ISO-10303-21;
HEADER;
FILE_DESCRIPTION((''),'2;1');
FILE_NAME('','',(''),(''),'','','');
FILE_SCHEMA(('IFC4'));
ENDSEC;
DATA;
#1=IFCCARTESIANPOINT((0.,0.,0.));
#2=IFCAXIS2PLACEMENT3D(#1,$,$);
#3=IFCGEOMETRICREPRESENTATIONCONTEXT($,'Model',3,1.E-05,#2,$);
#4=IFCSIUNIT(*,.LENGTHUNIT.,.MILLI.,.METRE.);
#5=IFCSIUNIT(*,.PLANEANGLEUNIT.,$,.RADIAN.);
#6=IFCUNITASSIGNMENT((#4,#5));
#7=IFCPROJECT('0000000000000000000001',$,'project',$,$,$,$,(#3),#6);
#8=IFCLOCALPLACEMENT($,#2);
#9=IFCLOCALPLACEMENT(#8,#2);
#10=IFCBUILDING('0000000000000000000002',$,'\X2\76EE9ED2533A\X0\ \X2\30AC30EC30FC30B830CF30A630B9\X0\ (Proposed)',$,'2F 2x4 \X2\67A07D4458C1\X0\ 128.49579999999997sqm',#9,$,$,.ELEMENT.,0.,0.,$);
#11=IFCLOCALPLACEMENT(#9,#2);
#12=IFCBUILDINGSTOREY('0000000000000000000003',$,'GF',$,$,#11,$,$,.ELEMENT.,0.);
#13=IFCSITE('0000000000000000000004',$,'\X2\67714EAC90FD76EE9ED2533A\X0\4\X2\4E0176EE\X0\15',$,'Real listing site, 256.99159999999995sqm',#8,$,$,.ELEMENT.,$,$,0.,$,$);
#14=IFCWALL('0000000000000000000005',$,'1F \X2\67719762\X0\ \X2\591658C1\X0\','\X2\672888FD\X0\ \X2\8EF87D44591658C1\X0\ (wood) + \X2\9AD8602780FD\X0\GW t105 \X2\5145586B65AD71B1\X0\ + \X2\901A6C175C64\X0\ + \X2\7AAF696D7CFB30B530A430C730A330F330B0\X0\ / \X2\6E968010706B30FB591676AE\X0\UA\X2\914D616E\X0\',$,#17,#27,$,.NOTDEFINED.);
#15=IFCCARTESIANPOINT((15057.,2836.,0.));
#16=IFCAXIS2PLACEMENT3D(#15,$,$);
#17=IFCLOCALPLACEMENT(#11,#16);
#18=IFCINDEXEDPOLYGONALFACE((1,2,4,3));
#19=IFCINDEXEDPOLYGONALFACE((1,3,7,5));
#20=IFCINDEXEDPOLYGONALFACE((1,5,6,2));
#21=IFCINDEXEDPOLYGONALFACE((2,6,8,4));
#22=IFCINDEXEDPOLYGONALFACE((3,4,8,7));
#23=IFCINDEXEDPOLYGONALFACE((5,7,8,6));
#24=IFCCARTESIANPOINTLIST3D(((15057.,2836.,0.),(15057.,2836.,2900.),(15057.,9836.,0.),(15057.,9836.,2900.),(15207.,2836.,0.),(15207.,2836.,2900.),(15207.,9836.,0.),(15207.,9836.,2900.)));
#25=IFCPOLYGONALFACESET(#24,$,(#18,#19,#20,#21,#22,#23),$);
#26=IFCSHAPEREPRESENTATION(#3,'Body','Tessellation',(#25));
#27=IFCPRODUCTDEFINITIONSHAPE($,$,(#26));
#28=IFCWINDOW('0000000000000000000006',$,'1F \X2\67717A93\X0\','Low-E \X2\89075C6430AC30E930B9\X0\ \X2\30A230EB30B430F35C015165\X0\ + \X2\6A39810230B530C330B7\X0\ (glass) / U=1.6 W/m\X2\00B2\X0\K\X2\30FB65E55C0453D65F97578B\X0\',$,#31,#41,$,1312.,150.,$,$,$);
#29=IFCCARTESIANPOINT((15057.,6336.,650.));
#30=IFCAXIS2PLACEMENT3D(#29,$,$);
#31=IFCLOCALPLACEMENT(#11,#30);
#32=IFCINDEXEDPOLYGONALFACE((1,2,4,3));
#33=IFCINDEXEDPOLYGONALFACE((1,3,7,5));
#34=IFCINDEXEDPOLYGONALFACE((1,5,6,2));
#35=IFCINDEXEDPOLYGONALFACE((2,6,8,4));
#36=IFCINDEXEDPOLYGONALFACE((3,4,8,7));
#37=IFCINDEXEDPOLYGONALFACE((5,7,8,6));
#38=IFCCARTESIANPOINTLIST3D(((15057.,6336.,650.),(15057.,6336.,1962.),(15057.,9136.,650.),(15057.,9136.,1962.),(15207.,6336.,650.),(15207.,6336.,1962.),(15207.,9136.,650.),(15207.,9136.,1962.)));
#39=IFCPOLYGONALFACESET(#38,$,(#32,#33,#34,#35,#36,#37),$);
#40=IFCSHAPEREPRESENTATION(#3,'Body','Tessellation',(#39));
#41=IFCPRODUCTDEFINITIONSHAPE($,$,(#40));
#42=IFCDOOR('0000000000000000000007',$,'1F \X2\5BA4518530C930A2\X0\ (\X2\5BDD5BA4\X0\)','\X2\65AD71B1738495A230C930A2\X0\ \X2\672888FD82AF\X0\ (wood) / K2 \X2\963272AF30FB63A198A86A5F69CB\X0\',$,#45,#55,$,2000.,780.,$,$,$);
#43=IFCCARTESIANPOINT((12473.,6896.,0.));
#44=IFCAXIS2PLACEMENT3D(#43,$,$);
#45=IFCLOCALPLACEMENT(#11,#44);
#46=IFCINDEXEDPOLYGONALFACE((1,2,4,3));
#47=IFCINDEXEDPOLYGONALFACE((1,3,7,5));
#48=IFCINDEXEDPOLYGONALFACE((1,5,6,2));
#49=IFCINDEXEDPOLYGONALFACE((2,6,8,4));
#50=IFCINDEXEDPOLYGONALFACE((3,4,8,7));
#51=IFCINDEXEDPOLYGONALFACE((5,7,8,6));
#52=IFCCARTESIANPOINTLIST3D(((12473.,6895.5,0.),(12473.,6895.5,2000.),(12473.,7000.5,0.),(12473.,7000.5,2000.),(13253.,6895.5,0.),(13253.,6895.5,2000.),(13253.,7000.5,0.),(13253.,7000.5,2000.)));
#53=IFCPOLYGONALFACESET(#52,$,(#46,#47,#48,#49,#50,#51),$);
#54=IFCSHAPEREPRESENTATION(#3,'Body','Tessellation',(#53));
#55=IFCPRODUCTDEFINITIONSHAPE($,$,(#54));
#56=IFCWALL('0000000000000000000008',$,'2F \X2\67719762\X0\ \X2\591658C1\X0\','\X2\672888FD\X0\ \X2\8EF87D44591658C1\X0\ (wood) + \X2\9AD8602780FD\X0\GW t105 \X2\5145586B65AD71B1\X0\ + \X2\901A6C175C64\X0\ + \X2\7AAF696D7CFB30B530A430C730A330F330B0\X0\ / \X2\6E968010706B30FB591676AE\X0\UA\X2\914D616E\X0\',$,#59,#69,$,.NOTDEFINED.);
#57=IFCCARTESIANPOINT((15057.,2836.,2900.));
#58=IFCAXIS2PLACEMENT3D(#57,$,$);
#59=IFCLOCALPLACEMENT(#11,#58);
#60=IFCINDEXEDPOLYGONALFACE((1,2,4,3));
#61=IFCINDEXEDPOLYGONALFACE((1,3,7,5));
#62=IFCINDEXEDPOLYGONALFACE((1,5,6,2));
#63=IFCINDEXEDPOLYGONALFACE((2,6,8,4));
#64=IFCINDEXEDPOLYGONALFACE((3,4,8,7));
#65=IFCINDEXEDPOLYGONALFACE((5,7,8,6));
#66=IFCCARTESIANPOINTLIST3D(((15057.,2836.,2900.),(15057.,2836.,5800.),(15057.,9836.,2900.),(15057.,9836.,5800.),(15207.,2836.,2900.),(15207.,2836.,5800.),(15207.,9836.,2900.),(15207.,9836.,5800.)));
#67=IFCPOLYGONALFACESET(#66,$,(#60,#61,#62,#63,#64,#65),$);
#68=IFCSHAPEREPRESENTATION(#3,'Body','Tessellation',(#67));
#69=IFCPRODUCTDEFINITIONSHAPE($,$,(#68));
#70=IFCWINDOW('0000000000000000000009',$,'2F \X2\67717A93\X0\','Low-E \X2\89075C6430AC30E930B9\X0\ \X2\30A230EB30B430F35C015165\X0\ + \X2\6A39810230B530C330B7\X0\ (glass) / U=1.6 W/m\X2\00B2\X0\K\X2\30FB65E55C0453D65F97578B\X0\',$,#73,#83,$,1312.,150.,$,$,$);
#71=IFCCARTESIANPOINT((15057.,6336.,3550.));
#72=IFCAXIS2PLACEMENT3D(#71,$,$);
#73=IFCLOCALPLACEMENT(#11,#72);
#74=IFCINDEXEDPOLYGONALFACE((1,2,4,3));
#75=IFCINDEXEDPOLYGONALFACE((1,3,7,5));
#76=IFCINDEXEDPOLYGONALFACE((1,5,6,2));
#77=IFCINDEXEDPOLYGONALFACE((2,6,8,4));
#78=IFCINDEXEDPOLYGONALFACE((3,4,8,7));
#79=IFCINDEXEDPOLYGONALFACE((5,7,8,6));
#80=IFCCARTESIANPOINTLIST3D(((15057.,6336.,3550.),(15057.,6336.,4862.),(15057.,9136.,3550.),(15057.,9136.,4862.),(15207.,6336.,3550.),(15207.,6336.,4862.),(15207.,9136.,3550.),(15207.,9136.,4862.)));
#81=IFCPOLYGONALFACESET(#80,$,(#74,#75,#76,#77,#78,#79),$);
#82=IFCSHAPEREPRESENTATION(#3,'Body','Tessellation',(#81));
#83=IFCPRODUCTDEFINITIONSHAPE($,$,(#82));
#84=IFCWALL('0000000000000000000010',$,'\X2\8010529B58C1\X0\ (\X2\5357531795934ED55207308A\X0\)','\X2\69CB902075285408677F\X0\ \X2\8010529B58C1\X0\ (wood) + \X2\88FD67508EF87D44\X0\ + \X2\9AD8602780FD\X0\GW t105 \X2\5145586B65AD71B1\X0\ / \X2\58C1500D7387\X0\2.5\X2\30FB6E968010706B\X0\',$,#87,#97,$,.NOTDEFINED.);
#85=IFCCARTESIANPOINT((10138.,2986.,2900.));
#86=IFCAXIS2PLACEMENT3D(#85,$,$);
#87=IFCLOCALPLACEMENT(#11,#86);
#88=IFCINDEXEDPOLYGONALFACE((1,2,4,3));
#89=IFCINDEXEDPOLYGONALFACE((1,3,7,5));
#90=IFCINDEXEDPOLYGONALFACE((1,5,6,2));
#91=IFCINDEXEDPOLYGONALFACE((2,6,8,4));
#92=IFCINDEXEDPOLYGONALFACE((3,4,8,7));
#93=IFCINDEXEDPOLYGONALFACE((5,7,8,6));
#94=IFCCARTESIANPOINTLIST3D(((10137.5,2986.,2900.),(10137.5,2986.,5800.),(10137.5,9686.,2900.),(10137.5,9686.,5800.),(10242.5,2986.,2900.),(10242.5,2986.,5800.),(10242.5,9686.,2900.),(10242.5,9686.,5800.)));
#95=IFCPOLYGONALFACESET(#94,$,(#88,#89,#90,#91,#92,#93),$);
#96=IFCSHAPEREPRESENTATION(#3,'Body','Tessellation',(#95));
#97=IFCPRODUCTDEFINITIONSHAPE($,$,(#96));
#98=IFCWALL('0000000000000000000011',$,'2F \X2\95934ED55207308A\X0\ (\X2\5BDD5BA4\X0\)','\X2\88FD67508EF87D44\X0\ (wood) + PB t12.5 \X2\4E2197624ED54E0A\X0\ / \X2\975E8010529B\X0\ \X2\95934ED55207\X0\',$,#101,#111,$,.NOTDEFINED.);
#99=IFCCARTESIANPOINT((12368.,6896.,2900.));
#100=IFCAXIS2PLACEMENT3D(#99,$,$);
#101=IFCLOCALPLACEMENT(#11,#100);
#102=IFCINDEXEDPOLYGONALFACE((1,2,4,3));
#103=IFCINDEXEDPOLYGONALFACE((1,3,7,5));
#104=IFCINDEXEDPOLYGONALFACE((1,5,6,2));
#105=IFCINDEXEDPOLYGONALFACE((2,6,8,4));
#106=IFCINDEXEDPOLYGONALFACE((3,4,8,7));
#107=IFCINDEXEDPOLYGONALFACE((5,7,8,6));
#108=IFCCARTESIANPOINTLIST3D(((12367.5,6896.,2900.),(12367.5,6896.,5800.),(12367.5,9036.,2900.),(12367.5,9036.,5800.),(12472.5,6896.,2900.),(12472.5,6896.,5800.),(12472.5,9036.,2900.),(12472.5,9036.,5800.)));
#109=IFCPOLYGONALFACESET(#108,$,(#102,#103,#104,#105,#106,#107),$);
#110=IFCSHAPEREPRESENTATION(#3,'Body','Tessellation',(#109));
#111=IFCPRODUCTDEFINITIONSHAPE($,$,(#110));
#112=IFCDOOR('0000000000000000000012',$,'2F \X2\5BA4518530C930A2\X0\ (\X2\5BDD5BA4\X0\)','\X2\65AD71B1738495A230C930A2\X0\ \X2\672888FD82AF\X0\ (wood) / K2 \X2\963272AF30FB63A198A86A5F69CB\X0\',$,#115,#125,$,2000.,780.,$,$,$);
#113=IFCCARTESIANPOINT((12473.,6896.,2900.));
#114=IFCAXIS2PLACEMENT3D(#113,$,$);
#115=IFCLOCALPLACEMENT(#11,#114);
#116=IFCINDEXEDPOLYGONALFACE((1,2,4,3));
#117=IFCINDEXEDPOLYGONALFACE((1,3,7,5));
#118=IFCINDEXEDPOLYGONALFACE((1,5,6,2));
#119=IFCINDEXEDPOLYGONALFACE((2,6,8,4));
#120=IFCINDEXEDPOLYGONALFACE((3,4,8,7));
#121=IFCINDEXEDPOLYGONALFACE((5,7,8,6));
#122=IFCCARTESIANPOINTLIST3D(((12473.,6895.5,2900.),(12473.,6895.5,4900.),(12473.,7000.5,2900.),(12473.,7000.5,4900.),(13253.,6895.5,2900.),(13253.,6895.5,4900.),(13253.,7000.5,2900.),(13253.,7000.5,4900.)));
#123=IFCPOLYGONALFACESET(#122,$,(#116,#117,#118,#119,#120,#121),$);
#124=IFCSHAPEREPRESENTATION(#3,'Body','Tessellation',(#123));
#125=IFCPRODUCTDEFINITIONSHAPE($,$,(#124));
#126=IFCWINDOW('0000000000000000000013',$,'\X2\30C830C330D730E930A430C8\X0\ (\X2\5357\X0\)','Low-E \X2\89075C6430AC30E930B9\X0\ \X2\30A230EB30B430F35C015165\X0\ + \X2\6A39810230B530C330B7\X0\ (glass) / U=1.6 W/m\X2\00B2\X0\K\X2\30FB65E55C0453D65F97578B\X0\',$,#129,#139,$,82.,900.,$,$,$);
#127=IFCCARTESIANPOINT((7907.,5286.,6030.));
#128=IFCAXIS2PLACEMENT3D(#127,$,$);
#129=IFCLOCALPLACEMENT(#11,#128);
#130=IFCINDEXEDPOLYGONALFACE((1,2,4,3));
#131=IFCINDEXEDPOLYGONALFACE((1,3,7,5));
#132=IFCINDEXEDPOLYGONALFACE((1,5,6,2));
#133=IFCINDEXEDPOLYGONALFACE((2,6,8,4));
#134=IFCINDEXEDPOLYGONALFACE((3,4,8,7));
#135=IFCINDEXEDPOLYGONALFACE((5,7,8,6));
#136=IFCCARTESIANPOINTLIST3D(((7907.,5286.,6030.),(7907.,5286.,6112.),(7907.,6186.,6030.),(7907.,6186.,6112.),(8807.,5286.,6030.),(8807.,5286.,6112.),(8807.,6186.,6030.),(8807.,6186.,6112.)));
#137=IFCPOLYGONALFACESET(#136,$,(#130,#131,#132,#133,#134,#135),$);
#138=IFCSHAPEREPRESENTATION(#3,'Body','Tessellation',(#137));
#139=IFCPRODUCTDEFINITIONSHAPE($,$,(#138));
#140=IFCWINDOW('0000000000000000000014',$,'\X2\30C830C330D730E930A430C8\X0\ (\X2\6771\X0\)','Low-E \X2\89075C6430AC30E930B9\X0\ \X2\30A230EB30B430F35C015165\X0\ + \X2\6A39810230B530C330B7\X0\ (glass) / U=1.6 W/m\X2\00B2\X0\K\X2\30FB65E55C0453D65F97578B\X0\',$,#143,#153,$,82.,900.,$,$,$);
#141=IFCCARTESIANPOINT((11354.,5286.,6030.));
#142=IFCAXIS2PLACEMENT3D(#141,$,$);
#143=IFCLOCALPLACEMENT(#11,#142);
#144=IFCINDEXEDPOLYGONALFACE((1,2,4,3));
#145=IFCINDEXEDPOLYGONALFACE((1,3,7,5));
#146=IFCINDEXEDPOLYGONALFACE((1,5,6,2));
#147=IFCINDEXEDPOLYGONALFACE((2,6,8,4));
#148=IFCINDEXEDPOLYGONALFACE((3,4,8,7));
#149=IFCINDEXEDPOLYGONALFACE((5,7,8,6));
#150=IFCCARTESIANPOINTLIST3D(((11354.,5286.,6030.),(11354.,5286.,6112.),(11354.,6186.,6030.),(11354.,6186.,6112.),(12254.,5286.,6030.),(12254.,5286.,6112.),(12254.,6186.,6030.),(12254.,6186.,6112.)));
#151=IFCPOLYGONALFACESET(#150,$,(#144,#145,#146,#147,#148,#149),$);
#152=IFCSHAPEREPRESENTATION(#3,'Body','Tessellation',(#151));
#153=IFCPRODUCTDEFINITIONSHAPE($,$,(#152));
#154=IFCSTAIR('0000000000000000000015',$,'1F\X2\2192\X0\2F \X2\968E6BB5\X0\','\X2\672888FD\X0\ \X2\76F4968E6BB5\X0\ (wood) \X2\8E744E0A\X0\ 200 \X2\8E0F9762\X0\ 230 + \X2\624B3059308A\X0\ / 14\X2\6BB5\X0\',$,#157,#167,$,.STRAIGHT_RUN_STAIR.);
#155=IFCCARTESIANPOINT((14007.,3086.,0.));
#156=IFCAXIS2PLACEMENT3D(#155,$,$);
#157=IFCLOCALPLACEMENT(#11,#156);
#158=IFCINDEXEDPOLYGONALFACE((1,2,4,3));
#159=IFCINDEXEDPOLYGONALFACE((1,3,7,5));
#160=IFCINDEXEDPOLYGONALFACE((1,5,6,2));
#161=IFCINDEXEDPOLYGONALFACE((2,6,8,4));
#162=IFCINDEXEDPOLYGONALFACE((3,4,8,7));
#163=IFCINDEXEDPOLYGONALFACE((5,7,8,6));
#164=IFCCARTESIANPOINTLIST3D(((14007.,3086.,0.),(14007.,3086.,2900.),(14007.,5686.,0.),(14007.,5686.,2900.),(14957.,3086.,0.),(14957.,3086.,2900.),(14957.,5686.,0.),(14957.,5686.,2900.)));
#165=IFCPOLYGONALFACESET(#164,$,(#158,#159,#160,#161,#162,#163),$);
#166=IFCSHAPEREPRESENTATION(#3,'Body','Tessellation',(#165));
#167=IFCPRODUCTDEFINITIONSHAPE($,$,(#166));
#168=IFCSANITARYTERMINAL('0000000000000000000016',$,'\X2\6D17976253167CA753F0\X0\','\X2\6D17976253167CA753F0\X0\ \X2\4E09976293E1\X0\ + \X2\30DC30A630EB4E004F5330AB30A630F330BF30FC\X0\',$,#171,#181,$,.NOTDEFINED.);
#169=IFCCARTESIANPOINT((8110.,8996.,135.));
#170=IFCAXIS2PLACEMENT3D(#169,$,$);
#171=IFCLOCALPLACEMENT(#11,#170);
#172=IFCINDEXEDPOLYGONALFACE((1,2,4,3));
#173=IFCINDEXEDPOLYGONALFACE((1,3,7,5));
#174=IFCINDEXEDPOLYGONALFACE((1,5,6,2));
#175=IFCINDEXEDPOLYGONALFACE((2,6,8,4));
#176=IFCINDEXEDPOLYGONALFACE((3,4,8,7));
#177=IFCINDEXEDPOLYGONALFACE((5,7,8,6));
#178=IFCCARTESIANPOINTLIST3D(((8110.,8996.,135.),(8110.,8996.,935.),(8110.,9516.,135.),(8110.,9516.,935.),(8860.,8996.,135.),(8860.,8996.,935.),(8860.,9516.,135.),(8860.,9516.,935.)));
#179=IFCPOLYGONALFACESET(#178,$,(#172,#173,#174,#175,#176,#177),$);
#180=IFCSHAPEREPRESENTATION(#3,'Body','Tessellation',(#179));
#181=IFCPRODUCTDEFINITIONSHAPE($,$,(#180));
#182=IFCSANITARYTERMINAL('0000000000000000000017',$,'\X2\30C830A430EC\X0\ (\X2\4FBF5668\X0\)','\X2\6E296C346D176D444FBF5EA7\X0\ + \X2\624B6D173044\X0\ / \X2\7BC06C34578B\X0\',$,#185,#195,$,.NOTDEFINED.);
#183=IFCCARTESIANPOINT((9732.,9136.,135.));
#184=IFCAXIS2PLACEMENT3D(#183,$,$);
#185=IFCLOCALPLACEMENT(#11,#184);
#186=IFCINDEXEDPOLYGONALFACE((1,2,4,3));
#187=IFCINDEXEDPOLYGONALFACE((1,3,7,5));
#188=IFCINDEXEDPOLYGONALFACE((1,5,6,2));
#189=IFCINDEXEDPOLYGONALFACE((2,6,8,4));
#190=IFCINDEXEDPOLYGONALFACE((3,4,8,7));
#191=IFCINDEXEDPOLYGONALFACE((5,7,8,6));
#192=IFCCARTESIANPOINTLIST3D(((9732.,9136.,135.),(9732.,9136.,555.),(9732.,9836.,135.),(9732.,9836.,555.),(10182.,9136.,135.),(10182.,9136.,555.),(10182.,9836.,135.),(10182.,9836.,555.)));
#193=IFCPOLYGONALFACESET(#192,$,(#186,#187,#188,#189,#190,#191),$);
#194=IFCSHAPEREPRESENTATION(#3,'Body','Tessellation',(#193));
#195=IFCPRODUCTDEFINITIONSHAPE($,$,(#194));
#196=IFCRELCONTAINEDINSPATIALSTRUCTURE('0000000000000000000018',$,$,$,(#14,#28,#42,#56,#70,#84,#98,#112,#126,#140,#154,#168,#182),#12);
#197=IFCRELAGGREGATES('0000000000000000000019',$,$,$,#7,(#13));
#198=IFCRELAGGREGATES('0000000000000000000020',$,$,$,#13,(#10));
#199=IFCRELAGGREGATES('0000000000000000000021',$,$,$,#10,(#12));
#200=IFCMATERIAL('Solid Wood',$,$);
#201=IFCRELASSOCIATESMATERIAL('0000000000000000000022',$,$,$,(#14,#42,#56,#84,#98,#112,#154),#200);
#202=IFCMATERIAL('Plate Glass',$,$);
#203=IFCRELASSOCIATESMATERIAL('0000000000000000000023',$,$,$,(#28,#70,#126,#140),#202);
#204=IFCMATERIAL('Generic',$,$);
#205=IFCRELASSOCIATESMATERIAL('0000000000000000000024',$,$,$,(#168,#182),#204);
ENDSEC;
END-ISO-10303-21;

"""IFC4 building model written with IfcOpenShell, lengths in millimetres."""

from ifc_helpers import new_model, si_unit, frame, frame_2d, origin, place, context, project, spatial, rectangle, extrude, material, element, fill, save


model = new_model("IFC4")

# Units and contexts
model_context = context("Model", 3, precision=1e-05, world=origin())
ifc_project = project(units=[si_unit("LENGTHUNIT", "METRE", prefix="MILLI"), si_unit("PLANEANGLEUNIT", "RADIAN")], contexts=[model_context])

# Site, building, storey
site_placement = place(None, origin())
site = spatial("IfcSite", under=ifc_project, at=site_placement, Name="東京都目黒区4丁目15", ObjectType="Real listing site, 256.99159999999995sqm", CompositionType="ELEMENT", RefElevation=0.0)
building_placement = place(site_placement, origin())
building = spatial("IfcBuilding", under=site, at=building_placement, Name="目黒区 ガレージハウス (Proposed)", ObjectType="2F 2x4 枠組壁 128.49579999999997sqm", CompositionType="ELEMENT", ElevationOfRefHeight=0.0, ElevationOfTerrain=0.0)
storey_placement = place(building_placement, origin())
storey = spatial("IfcBuildingStorey", under=building, at=storey_placement, Name="GF", CompositionType="ELEMENT", Elevation=0.0)

# Wall, opening, window
ifc_material_1 = material(Name="Solid Wood")
wall_1_placement = place(storey_placement, frame((15057.0, 2836.0, 0.0)))
wall_1 = element("IfcWall", 1, at=wall_1_placement, inside=storey, material=ifc_material_1, Name="1F 東面 外壁", Description="木製 軸組外壁 (wood) + 高性能GW t105 充填断熱 + 通気層 + 窯業系サイディング / 準耐火・外皮UA配慮", PredefinedType="NOTDEFINED", context=model_context, shape_type="SweptSolid", body=[
    extrude(rectangle(XDim=150.0, YDim=7000.0, at=frame_2d((75.0, 3500.0))), frame((15057.0, 2836.0, 0.0)), (0.0, 0.0, 1.0), 2900.0),
])
opening_1_placement = place(storey_placement, frame((15057.0, 6336.0, 650.0)))
opening_1 = element("IfcOpeningElement", 2, at=opening_1_placement, cuts=wall_1, PredefinedType="NOTDEFINED", context=model_context, shape_type="SweptSolid", body=[
    extrude(rectangle(XDim=150.0, YDim=2800.0, at=frame_2d((75.0, 1400.0))), frame((15057.0, 6336.0, 650.0)), (0.0, 0.0, 1.0), 1312.0),
])
ifc_material_2 = material(Name="Plate Glass")
window_1_placement = place(storey_placement, frame((15057.0, 6336.0, 650.0)))
window_1 = element("IfcWindow", 3, at=window_1_placement, inside=storey, material=ifc_material_2, Name="1F 東窓", Description="Low-E 複層ガラス アルゴン封入 + 樹脂サッシ (glass) / U=1.6 W/m²K・日射取得型", OverallHeight=1312.0, OverallWidth=150.0, context=model_context, shape_type="SweptSolid", body=[
    extrude(rectangle(XDim=150.0, YDim=2800.0, at=frame_2d((75.0, 1400.0))), frame((15057.0, 6336.0, 650.0)), (0.0, 0.0, 1.0), 1312.0),
])
fill(opening_1, window_1)

# Door
door_1_placement = place(storey_placement, frame((12473.0, 6896.0, 0.0)))
element("IfcDoor", 4, at=door_1_placement, inside=storey, material=ifc_material_1, Name="1F 室内ドア (寝室)", Description="断熱玄関ドア 木製芯 (wood) / K2 防犯・採風機構", OverallHeight=2000.0, OverallWidth=780.0, context=model_context, shape_type="SweptSolid", body=[
    extrude(rectangle(XDim=780.0, YDim=105.0, at=frame_2d((390.0, 52.0))), frame((12473.0, 6896.0, 0.0)), (0.0, 0.0, 1.0), 2000.0),
])

# Wall, opening, window
wall_2_placement = place(storey_placement, frame((15057.0, 2836.0, 2900.0)))
wall_2 = element("IfcWall", 5, at=wall_2_placement, inside=storey, material=ifc_material_1, Name="2F 東面 外壁", Description="木製 軸組外壁 (wood) + 高性能GW t105 充填断熱 + 通気層 + 窯業系サイディング / 準耐火・外皮UA配慮", PredefinedType="NOTDEFINED", context=model_context, shape_type="SweptSolid", body=[
    extrude(rectangle(XDim=150.0, YDim=7000.0, at=frame_2d((75.0, 3500.0))), frame((15057.0, 2836.0, 2900.0)), (0.0, 0.0, 1.0), 2900.0),
])
opening_2_placement = place(storey_placement, frame((15057.0, 6336.0, 3550.0)))
opening_2 = element("IfcOpeningElement", 6, at=opening_2_placement, cuts=wall_2, PredefinedType="NOTDEFINED", context=model_context, shape_type="SweptSolid", body=[
    extrude(rectangle(XDim=150.0, YDim=2800.0, at=frame_2d((75.0, 1400.0))), frame((15057.0, 6336.0, 3550.0)), (0.0, 0.0, 1.0), 1312.0),
])
window_2_placement = place(storey_placement, frame((15057.0, 6336.0, 3550.0)))
window_2 = element("IfcWindow", 7, at=window_2_placement, inside=storey, material=ifc_material_2, Name="2F 東窓", Description="Low-E 複層ガラス アルゴン封入 + 樹脂サッシ (glass) / U=1.6 W/m²K・日射取得型", OverallHeight=1312.0, OverallWidth=150.0, context=model_context, shape_type="SweptSolid", body=[
    extrude(rectangle(XDim=150.0, YDim=2800.0, at=frame_2d((75.0, 1400.0))), frame((15057.0, 6336.0, 3550.0)), (0.0, 0.0, 1.0), 1312.0),
])
fill(opening_2, window_2)

# Walls
wall_3_placement = place(storey_placement, frame((10138.0, 2986.0, 2900.0)))
element("IfcWall", 8, at=wall_3_placement, inside=storey, material=ifc_material_1, Name="耐力壁 (南北間仕切り)", Description="構造用合板 耐力壁 (wood) + 製材軸組 + 高性能GW t105 充填断熱 / 壁倍率2.5・準耐火", PredefinedType="NOTDEFINED", context=model_context, shape_type="SweptSolid", body=[
    extrude(rectangle(XDim=105.0, YDim=6700.0, at=frame_2d((52.0, 3350.0))), frame((10138.0, 2986.0, 2900.0)), (0.0, 0.0, 1.0), 2900.0),
])
wall_4_placement = place(storey_placement, frame((12368.0, 6896.0, 2900.0)))
element("IfcWall", 9, at=wall_4_placement, inside=storey, material=ifc_material_1, Name="2F 間仕切り (寝室)", Description="製材軸組 (wood) + PB t12.5 両面仕上 / 非耐力 間仕切", PredefinedType="NOTDEFINED", context=model_context, shape_type="SweptSolid", body=[
    extrude(rectangle(XDim=105.0, YDim=2140.0, at=frame_2d((52.0, 1070.0))), frame((12368.0, 6896.0, 2900.0)), (0.0, 0.0, 1.0), 2900.0),
])

# Door
door_2_placement = place(storey_placement, frame((12473.0, 6896.0, 2900.0)))
element("IfcDoor", 10, at=door_2_placement, inside=storey, material=ifc_material_1, Name="2F 室内ドア (寝室)", Description="断熱玄関ドア 木製芯 (wood) / K2 防犯・採風機構", OverallHeight=2000.0, OverallWidth=780.0, context=model_context, shape_type="SweptSolid", body=[
    extrude(rectangle(XDim=780.0, YDim=105.0, at=frame_2d((390.0, 52.0))), frame((12473.0, 6896.0, 2900.0)), (0.0, 0.0, 1.0), 2000.0),
])

# Windows
window_3_placement = place(storey_placement, frame((7907.0, 5286.0, 6030.0)))
element("IfcWindow", 11, at=window_3_placement, inside=storey, material=ifc_material_2, Name="トップライト (南)", Description="Low-E 複層ガラス アルゴン封入 + 樹脂サッシ (glass) / U=1.6 W/m²K・日射取得型", OverallHeight=82.0, OverallWidth=900.0, context=model_context, shape_type="SweptSolid", body=[
    extrude(rectangle(XDim=900.0, YDim=900.0, at=frame_2d((450.0, 450.0))), frame((7907.0, 5286.0, 6030.0)), (0.0, 0.0, 1.0), 82.0),
])
window_4_placement = place(storey_placement, frame((11354.0, 5286.0, 6030.0)))
element("IfcWindow", 12, at=window_4_placement, inside=storey, material=ifc_material_2, Name="トップライト (東)", Description="Low-E 複層ガラス アルゴン封入 + 樹脂サッシ (glass) / U=1.6 W/m²K・日射取得型", OverallHeight=82.0, OverallWidth=900.0, context=model_context, shape_type="SweptSolid", body=[
    extrude(rectangle(XDim=900.0, YDim=900.0, at=frame_2d((450.0, 450.0))), frame((11354.0, 5286.0, 6030.0)), (0.0, 0.0, 1.0), 82.0),
])

# Stair
stair_placement = place(storey_placement, frame((14007.0, 3086.0, 0.0)))
element("IfcStair", 13, at=stair_placement, inside=storey, material=ifc_material_1, Name="1F→2F 階段", Description="木製 直階段 (wood) 蹴上 200 踏面 230 + 手すり / 14段", PredefinedType="STRAIGHT_RUN_STAIR", context=model_context, shape_type="SweptSolid", body=[
    extrude(rectangle(XDim=950.0, YDim=2600.0, at=frame_2d((475.0, 1300.0))), frame((14007.0, 3086.0, 0.0)), (0.0, 0.0, 1.0), 2900.0),
])

# Sanitary terminals
ifc_material_3 = material(Name="Generic")
sanitary_terminal_1_placement = place(storey_placement, frame((8110.0, 8996.0, 135.0)))
element("IfcSanitaryTerminal", 14, at=sanitary_terminal_1_placement, inside=storey, material=ifc_material_3, Name="洗面化粧台", Description="洗面化粧台 三面鏡 + ボウル一体カウンター", PredefinedType="NOTDEFINED", context=model_context, shape_type="SweptSolid", body=[
    extrude(rectangle(XDim=750.0, YDim=520.0, at=frame_2d((375.0, 260.0))), frame((8110.0, 8996.0, 135.0)), (0.0, 0.0, 1.0), 800.0),
])
sanitary_terminal_2_placement = place(storey_placement, frame((9732.0, 9136.0, 135.0)))
element("IfcSanitaryTerminal", 15, at=sanitary_terminal_2_placement, inside=storey, material=ifc_material_3, Name="トイレ (便器)", Description="温水洗浄便座 + 手洗い / 節水型", PredefinedType="NOTDEFINED", context=model_context, shape_type="SweptSolid", body=[
    extrude(rectangle(XDim=450.0, YDim=700.0, at=frame_2d((225.0, 350.0))), frame((9732.0, 9136.0, 135.0)), (0.0, 0.0, 1.0), 420.0),
])

save(model, "model.ifc")
